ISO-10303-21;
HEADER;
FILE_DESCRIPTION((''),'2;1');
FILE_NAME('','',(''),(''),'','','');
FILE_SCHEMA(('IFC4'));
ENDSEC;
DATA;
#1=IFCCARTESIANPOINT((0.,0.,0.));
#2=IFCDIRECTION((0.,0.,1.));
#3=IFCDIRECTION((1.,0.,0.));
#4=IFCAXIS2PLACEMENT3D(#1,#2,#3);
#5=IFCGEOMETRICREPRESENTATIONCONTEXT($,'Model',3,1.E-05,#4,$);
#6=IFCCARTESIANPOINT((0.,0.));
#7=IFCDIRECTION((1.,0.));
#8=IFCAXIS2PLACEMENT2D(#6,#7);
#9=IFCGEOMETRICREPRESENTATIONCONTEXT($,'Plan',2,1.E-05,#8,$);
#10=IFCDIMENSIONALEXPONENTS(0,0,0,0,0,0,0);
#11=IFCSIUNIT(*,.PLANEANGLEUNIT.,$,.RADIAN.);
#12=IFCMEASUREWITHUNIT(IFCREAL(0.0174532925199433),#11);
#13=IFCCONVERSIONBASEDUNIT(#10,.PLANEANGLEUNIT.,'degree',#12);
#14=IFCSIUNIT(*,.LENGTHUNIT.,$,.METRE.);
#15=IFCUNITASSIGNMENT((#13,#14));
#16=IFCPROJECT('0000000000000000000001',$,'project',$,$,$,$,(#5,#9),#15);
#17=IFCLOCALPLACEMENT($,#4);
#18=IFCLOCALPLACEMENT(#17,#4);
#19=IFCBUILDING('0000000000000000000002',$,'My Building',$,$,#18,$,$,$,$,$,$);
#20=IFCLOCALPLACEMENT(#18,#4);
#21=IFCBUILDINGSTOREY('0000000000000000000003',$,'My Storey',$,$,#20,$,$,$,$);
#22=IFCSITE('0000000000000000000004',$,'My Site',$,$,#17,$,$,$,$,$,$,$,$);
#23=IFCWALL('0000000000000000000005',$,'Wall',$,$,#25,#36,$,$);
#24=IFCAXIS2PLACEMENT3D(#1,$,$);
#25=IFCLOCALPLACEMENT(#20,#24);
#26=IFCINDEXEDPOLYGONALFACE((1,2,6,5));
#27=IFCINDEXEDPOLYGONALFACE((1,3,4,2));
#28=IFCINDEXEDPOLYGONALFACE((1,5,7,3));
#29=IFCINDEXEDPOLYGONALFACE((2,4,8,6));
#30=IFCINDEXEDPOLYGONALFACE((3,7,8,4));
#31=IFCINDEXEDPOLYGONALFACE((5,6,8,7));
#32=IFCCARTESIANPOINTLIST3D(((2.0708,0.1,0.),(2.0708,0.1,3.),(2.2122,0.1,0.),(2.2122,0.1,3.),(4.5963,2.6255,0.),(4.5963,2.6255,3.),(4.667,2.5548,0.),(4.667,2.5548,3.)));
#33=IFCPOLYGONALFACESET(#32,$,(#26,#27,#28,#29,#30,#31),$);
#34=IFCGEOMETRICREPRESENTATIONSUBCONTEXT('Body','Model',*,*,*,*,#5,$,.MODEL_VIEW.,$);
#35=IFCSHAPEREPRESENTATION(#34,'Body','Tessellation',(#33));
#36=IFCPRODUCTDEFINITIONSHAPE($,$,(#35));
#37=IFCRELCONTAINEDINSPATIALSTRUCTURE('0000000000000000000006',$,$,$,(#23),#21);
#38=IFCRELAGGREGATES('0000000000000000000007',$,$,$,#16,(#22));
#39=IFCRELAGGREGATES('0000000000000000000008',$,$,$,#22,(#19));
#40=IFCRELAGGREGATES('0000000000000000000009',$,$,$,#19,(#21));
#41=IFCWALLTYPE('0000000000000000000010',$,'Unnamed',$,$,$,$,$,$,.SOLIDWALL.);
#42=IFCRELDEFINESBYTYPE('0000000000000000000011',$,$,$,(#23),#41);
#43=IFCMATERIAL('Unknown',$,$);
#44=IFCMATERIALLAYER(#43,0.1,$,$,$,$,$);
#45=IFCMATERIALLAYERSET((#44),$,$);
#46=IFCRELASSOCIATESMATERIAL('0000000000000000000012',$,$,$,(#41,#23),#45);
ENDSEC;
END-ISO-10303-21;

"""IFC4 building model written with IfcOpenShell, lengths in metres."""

from ifc_helpers import new_model, entity, si_unit, converted_unit, frame, origin_with_axes, origin_2d_with_axis, place, context, subcontext, project, spatial, line, indexed_curve, outline, extrude, material, layer, layer_set, layer_usage, type_object, element, save


model = new_model("IFC4")

# Units and contexts
model_context = context("Model", 3, precision=1e-05, world=origin_with_axes())
plan_context = context("Plan", 2, precision=1e-05, world=origin_2d_with_axis())
body_context = subcontext(model_context, "Body", "Model", "MODEL_VIEW")
ifc_project = project(units=[converted_unit("PLANEANGLEUNIT", "degree", entity("IfcReal", 0.0174532925199433), si_unit("PLANEANGLEUNIT", "RADIAN"), dimensions=[0, 0, 0, 0, 0, 0, 0]), si_unit("LENGTHUNIT", "METRE")], contexts=[model_context, plan_context])

# Site, building, storey
site_placement = place(None, origin_with_axes())
site = spatial("IfcSite", under=ifc_project, at=site_placement, Name="My Site")
building_placement = place(site_placement, origin_with_axes())
building = spatial("IfcBuilding", under=site, at=building_placement, Name="My Building")
storey_placement = place(building_placement, origin_with_axes())
storey = spatial("IfcBuildingStorey", under=building, at=storey_placement, Name="My Storey")

# Shared definitions
ifc_material = material(Name="Unknown")
ifc_layer = layer(ifc_material, 0.1)
ifc_layer_set = layer_set([ifc_layer])
wall_type = type_object("IfcWallType", Name="Unnamed", PredefinedType="SOLIDWALL", material=ifc_layer_set)

# Wall
ifc_layer_usage_1 = layer_usage(ifc_layer_set, "AXIS2", "POSITIVE", 0.0)
wall_1_placement = place(storey_placement, frame((4.5963, 2.6255, 0.0), z_axis=(0.0, 0.0, 1.0), x_axis=(-0.707107, -0.707107, 0.0)))
element("IfcWall", 1, at=wall_1_placement, inside=storey, type_object=wall_type, material=ifc_layer_usage_1, Name="Wall", context=body_context, shape_type="SweptSolid", body=[
    extrude(outline(indexed_curve([(0.0, 0.0), (0.0, 0.1), (3.4716, 0.1), (3.5716, 0.0)], segments=[line(1, 2, 3, 4, 1)])), origin_with_axes(), (0.0, 0.0, 1.0), 3.0),
])

save(model, "model.ifc")
